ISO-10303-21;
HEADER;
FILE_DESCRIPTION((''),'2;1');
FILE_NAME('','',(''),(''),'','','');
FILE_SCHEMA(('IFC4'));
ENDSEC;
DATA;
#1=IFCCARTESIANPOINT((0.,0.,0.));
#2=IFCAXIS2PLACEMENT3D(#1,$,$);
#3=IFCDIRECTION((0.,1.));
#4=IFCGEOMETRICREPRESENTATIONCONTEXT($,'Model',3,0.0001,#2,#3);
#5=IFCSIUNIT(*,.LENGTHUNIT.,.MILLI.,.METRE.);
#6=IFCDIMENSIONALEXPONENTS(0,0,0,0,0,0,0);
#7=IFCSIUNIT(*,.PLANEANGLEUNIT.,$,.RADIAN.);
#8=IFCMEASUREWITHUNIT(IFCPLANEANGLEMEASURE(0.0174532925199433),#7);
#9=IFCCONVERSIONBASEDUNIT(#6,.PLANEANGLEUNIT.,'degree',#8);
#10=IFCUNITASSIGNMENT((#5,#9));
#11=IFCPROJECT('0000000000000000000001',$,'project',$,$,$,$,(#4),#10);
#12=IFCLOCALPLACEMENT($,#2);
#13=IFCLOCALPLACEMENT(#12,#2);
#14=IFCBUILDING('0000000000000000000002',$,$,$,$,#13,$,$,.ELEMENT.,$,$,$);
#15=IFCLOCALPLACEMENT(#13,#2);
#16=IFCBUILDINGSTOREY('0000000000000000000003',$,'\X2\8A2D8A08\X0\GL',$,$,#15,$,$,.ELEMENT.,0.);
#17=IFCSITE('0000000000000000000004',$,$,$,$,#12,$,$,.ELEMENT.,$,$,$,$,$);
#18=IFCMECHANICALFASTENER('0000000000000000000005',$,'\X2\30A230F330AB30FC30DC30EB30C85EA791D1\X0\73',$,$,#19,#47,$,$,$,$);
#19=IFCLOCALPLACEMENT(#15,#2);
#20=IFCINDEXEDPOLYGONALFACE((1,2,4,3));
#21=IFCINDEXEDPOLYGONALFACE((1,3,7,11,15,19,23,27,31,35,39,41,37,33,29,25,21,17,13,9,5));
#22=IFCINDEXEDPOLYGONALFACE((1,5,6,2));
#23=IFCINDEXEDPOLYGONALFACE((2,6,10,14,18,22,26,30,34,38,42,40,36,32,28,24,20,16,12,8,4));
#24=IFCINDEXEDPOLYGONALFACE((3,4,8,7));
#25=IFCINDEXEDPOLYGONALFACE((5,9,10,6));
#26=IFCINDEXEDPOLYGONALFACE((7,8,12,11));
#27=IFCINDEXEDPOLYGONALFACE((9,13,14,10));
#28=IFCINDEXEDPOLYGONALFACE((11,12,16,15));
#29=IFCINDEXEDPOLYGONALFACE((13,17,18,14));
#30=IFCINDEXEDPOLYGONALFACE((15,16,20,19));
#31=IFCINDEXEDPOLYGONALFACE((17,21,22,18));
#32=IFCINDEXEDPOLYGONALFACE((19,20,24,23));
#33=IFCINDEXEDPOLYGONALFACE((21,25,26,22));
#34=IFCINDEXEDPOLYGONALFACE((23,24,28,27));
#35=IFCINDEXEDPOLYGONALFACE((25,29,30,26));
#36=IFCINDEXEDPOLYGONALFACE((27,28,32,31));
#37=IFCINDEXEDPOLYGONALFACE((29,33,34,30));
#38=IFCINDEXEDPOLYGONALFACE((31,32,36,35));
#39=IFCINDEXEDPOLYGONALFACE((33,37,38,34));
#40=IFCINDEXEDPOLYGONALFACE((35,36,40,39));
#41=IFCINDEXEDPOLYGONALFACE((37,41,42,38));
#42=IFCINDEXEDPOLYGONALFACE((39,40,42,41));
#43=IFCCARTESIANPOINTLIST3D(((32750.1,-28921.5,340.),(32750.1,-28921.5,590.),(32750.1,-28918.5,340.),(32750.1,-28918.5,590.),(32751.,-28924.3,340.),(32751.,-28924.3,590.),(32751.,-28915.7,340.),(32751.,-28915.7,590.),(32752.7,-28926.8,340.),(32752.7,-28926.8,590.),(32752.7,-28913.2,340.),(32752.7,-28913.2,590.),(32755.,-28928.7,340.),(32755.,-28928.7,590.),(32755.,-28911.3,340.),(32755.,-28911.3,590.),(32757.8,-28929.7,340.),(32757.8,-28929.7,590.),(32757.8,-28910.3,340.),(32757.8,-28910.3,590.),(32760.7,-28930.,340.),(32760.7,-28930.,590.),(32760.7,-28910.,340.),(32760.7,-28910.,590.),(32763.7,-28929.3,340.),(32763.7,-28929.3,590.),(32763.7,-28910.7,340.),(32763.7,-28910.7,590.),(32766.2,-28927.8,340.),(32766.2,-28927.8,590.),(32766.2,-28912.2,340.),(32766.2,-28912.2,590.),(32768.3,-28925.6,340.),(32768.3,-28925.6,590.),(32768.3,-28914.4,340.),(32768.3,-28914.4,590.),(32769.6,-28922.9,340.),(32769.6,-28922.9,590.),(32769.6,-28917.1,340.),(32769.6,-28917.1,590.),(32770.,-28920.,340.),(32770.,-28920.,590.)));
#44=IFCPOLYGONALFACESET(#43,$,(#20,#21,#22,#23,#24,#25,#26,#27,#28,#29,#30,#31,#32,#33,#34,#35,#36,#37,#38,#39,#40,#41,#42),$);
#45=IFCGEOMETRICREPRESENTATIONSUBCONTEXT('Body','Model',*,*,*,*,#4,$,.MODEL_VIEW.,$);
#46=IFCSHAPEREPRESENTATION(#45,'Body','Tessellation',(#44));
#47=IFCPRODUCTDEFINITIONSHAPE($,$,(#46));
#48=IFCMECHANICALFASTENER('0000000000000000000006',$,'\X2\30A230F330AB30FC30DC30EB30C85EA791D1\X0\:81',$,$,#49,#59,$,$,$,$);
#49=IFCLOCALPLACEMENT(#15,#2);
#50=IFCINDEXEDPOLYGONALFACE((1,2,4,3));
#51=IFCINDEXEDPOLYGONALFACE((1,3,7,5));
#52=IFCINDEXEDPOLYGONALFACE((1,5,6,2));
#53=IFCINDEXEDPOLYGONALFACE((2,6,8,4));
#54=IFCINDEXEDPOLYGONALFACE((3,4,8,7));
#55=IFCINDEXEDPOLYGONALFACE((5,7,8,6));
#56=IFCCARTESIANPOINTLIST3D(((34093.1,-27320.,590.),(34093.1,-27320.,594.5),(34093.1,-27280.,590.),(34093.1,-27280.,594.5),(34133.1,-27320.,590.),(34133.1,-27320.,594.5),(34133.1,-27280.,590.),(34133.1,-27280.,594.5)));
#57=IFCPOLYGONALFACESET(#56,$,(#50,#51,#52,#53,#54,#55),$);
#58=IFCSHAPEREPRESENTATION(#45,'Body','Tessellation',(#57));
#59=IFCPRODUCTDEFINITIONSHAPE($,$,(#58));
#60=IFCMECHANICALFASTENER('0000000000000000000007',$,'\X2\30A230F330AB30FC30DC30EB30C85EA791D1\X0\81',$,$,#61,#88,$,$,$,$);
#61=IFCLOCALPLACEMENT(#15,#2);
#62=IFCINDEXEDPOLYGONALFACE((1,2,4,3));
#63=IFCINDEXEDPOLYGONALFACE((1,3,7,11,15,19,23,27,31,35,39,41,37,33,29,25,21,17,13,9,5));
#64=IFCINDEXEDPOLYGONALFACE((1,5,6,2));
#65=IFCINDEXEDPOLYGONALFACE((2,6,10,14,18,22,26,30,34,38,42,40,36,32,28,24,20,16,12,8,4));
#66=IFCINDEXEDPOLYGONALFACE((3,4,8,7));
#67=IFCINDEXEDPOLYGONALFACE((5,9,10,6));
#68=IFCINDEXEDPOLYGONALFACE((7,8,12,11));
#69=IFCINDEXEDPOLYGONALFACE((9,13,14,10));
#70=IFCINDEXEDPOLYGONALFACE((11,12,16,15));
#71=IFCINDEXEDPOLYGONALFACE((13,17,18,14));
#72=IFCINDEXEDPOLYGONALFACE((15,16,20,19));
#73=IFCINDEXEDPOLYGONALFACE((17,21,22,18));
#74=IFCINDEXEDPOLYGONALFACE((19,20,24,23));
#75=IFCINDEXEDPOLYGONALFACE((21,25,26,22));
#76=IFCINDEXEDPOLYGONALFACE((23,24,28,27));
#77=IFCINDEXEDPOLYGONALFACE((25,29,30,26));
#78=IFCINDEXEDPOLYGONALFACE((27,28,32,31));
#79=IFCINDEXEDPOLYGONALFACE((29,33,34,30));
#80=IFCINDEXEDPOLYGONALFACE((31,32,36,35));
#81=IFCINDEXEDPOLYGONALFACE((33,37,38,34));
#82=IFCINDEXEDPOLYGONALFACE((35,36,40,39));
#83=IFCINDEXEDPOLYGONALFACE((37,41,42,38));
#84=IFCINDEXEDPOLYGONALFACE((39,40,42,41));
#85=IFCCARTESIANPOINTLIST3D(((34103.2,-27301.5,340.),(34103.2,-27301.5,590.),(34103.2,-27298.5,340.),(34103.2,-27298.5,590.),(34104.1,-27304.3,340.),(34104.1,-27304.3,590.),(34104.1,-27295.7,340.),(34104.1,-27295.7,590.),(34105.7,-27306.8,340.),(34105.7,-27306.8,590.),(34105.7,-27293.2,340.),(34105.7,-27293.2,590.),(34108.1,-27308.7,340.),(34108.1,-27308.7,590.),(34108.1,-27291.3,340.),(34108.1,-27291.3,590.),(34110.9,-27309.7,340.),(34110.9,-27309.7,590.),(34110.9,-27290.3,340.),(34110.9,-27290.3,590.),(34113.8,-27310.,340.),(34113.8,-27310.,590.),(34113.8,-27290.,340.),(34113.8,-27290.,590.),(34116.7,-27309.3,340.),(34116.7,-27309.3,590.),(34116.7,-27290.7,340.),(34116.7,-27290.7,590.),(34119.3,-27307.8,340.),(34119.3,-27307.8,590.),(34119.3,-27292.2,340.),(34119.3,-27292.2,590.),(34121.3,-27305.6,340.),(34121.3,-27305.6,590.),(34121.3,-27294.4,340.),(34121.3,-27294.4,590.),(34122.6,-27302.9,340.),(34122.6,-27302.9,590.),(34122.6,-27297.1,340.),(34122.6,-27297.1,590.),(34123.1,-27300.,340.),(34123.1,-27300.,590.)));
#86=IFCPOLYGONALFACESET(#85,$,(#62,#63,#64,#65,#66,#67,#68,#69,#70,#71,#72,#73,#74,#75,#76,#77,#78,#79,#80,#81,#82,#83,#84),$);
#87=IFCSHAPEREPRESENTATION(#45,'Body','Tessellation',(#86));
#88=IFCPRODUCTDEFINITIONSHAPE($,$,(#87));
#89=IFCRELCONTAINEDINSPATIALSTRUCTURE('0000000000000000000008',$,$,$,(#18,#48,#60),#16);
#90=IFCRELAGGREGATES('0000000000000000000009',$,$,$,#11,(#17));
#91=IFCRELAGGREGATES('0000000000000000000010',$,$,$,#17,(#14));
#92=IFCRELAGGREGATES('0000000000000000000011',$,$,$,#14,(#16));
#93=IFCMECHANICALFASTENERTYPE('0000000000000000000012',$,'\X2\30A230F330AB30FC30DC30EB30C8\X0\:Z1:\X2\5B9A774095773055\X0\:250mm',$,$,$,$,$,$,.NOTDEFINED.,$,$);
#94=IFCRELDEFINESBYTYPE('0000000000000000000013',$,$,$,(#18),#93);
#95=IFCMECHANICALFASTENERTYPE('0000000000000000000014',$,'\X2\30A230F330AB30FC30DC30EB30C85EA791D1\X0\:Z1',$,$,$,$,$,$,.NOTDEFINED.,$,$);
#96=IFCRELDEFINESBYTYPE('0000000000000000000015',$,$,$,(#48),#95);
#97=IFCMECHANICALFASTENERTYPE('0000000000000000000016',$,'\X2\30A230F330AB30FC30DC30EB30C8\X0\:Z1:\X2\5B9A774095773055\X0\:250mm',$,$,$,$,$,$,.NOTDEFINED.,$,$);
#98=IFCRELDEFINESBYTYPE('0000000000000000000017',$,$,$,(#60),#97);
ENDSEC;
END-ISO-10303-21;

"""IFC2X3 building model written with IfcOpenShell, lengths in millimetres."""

from ifc_helpers import new_model, entity, si_unit, converted_unit, direction, frame, origin, origin_with_axes, origin_2d, place, context, subcontext, project, spatial, rectangle, circle, extrude, type_object, element, save


model = new_model("IFC2X3")

# Units and contexts
model_context = context("Model", 3, precision=0.0001, world=origin(), true_north=direction((0.0, 1.0)))
body_context = subcontext(model_context, "Body", "Model", "MODEL_VIEW")
ifc_project = project(units=[si_unit("LENGTHUNIT", "METRE", prefix="MILLI"), converted_unit("PLANEANGLEUNIT", "degree", entity("IfcPlaneAngleMeasure", 0.0174532925199433), si_unit("PLANEANGLEUNIT", "RADIAN"), dimensions=[0, 0, 0, 0, 0, 0, 0])], contexts=[model_context])

# Site, building, storey
site_placement = place(None, origin())
site = spatial("IfcSite", under=ifc_project, at=site_placement, CompositionType="ELEMENT")
building_placement = place(site_placement, origin())
building = spatial("IfcBuilding", under=site, at=building_placement, CompositionType="ELEMENT")
storey_placement = place(building_placement, origin())
storey = spatial("IfcBuildingStorey", under=building, at=storey_placement, Name="設計GL", CompositionType="ELEMENT", Elevation=0.0)

# Mechanical fasteners
mechanical_fastener_type_1 = type_object("IfcMechanicalFastenerType", Name="アンカーボルト:Z1:定着長さ:250mm")
mechanical_fastener_1_placement = place(storey_placement, frame((32760.0, -28920.0, 340.0)))
element("IfcMechanicalFastener", 1, at=mechanical_fastener_1_placement, inside=storey, type_object=mechanical_fastener_type_1, Name="アンカーボルト座金73", context=body_context, shape_type="SweptSolid", body=[
    extrude(circle(Radius=10.0, at=origin_2d()), origin_with_axes(), (0.0, 0.0, 1.0), 250.0),
])
mechanical_fastener_type_2 = type_object("IfcMechanicalFastenerType", Name="アンカーボルト座金:Z1")
mechanical_fastener_2_placement = place(storey_placement, frame((34113.1, -27300.0, 590.0)))
element("IfcMechanicalFastener", 2, at=mechanical_fastener_2_placement, inside=storey, type_object=mechanical_fastener_type_2, Name="アンカーボルト座金:81", context=body_context, shape_type="SweptSolid", body=[
    extrude(rectangle(XDim=40.0, YDim=40.0, at=origin_2d()), origin_with_axes(), (0.0, 0.0, 1.0), 4.5),
])
mechanical_fastener_type_3 = type_object("IfcMechanicalFastenerType", Name="アンカーボルト:Z1:定着長さ:250mm")
mechanical_fastener_3_placement = place(storey_placement, frame((34113.1, -27300.0, 340.0)))
element("IfcMechanicalFastener", 3, at=mechanical_fastener_3_placement, inside=storey, type_object=mechanical_fastener_type_3, Name="アンカーボルト座金81", context=body_context, shape_type="SweptSolid", body=[
    extrude(circle(Radius=10.0, at=origin_2d()), origin_with_axes(), (0.0, 0.0, 1.0), 250.0),
])

save(model, "model.ifc")
